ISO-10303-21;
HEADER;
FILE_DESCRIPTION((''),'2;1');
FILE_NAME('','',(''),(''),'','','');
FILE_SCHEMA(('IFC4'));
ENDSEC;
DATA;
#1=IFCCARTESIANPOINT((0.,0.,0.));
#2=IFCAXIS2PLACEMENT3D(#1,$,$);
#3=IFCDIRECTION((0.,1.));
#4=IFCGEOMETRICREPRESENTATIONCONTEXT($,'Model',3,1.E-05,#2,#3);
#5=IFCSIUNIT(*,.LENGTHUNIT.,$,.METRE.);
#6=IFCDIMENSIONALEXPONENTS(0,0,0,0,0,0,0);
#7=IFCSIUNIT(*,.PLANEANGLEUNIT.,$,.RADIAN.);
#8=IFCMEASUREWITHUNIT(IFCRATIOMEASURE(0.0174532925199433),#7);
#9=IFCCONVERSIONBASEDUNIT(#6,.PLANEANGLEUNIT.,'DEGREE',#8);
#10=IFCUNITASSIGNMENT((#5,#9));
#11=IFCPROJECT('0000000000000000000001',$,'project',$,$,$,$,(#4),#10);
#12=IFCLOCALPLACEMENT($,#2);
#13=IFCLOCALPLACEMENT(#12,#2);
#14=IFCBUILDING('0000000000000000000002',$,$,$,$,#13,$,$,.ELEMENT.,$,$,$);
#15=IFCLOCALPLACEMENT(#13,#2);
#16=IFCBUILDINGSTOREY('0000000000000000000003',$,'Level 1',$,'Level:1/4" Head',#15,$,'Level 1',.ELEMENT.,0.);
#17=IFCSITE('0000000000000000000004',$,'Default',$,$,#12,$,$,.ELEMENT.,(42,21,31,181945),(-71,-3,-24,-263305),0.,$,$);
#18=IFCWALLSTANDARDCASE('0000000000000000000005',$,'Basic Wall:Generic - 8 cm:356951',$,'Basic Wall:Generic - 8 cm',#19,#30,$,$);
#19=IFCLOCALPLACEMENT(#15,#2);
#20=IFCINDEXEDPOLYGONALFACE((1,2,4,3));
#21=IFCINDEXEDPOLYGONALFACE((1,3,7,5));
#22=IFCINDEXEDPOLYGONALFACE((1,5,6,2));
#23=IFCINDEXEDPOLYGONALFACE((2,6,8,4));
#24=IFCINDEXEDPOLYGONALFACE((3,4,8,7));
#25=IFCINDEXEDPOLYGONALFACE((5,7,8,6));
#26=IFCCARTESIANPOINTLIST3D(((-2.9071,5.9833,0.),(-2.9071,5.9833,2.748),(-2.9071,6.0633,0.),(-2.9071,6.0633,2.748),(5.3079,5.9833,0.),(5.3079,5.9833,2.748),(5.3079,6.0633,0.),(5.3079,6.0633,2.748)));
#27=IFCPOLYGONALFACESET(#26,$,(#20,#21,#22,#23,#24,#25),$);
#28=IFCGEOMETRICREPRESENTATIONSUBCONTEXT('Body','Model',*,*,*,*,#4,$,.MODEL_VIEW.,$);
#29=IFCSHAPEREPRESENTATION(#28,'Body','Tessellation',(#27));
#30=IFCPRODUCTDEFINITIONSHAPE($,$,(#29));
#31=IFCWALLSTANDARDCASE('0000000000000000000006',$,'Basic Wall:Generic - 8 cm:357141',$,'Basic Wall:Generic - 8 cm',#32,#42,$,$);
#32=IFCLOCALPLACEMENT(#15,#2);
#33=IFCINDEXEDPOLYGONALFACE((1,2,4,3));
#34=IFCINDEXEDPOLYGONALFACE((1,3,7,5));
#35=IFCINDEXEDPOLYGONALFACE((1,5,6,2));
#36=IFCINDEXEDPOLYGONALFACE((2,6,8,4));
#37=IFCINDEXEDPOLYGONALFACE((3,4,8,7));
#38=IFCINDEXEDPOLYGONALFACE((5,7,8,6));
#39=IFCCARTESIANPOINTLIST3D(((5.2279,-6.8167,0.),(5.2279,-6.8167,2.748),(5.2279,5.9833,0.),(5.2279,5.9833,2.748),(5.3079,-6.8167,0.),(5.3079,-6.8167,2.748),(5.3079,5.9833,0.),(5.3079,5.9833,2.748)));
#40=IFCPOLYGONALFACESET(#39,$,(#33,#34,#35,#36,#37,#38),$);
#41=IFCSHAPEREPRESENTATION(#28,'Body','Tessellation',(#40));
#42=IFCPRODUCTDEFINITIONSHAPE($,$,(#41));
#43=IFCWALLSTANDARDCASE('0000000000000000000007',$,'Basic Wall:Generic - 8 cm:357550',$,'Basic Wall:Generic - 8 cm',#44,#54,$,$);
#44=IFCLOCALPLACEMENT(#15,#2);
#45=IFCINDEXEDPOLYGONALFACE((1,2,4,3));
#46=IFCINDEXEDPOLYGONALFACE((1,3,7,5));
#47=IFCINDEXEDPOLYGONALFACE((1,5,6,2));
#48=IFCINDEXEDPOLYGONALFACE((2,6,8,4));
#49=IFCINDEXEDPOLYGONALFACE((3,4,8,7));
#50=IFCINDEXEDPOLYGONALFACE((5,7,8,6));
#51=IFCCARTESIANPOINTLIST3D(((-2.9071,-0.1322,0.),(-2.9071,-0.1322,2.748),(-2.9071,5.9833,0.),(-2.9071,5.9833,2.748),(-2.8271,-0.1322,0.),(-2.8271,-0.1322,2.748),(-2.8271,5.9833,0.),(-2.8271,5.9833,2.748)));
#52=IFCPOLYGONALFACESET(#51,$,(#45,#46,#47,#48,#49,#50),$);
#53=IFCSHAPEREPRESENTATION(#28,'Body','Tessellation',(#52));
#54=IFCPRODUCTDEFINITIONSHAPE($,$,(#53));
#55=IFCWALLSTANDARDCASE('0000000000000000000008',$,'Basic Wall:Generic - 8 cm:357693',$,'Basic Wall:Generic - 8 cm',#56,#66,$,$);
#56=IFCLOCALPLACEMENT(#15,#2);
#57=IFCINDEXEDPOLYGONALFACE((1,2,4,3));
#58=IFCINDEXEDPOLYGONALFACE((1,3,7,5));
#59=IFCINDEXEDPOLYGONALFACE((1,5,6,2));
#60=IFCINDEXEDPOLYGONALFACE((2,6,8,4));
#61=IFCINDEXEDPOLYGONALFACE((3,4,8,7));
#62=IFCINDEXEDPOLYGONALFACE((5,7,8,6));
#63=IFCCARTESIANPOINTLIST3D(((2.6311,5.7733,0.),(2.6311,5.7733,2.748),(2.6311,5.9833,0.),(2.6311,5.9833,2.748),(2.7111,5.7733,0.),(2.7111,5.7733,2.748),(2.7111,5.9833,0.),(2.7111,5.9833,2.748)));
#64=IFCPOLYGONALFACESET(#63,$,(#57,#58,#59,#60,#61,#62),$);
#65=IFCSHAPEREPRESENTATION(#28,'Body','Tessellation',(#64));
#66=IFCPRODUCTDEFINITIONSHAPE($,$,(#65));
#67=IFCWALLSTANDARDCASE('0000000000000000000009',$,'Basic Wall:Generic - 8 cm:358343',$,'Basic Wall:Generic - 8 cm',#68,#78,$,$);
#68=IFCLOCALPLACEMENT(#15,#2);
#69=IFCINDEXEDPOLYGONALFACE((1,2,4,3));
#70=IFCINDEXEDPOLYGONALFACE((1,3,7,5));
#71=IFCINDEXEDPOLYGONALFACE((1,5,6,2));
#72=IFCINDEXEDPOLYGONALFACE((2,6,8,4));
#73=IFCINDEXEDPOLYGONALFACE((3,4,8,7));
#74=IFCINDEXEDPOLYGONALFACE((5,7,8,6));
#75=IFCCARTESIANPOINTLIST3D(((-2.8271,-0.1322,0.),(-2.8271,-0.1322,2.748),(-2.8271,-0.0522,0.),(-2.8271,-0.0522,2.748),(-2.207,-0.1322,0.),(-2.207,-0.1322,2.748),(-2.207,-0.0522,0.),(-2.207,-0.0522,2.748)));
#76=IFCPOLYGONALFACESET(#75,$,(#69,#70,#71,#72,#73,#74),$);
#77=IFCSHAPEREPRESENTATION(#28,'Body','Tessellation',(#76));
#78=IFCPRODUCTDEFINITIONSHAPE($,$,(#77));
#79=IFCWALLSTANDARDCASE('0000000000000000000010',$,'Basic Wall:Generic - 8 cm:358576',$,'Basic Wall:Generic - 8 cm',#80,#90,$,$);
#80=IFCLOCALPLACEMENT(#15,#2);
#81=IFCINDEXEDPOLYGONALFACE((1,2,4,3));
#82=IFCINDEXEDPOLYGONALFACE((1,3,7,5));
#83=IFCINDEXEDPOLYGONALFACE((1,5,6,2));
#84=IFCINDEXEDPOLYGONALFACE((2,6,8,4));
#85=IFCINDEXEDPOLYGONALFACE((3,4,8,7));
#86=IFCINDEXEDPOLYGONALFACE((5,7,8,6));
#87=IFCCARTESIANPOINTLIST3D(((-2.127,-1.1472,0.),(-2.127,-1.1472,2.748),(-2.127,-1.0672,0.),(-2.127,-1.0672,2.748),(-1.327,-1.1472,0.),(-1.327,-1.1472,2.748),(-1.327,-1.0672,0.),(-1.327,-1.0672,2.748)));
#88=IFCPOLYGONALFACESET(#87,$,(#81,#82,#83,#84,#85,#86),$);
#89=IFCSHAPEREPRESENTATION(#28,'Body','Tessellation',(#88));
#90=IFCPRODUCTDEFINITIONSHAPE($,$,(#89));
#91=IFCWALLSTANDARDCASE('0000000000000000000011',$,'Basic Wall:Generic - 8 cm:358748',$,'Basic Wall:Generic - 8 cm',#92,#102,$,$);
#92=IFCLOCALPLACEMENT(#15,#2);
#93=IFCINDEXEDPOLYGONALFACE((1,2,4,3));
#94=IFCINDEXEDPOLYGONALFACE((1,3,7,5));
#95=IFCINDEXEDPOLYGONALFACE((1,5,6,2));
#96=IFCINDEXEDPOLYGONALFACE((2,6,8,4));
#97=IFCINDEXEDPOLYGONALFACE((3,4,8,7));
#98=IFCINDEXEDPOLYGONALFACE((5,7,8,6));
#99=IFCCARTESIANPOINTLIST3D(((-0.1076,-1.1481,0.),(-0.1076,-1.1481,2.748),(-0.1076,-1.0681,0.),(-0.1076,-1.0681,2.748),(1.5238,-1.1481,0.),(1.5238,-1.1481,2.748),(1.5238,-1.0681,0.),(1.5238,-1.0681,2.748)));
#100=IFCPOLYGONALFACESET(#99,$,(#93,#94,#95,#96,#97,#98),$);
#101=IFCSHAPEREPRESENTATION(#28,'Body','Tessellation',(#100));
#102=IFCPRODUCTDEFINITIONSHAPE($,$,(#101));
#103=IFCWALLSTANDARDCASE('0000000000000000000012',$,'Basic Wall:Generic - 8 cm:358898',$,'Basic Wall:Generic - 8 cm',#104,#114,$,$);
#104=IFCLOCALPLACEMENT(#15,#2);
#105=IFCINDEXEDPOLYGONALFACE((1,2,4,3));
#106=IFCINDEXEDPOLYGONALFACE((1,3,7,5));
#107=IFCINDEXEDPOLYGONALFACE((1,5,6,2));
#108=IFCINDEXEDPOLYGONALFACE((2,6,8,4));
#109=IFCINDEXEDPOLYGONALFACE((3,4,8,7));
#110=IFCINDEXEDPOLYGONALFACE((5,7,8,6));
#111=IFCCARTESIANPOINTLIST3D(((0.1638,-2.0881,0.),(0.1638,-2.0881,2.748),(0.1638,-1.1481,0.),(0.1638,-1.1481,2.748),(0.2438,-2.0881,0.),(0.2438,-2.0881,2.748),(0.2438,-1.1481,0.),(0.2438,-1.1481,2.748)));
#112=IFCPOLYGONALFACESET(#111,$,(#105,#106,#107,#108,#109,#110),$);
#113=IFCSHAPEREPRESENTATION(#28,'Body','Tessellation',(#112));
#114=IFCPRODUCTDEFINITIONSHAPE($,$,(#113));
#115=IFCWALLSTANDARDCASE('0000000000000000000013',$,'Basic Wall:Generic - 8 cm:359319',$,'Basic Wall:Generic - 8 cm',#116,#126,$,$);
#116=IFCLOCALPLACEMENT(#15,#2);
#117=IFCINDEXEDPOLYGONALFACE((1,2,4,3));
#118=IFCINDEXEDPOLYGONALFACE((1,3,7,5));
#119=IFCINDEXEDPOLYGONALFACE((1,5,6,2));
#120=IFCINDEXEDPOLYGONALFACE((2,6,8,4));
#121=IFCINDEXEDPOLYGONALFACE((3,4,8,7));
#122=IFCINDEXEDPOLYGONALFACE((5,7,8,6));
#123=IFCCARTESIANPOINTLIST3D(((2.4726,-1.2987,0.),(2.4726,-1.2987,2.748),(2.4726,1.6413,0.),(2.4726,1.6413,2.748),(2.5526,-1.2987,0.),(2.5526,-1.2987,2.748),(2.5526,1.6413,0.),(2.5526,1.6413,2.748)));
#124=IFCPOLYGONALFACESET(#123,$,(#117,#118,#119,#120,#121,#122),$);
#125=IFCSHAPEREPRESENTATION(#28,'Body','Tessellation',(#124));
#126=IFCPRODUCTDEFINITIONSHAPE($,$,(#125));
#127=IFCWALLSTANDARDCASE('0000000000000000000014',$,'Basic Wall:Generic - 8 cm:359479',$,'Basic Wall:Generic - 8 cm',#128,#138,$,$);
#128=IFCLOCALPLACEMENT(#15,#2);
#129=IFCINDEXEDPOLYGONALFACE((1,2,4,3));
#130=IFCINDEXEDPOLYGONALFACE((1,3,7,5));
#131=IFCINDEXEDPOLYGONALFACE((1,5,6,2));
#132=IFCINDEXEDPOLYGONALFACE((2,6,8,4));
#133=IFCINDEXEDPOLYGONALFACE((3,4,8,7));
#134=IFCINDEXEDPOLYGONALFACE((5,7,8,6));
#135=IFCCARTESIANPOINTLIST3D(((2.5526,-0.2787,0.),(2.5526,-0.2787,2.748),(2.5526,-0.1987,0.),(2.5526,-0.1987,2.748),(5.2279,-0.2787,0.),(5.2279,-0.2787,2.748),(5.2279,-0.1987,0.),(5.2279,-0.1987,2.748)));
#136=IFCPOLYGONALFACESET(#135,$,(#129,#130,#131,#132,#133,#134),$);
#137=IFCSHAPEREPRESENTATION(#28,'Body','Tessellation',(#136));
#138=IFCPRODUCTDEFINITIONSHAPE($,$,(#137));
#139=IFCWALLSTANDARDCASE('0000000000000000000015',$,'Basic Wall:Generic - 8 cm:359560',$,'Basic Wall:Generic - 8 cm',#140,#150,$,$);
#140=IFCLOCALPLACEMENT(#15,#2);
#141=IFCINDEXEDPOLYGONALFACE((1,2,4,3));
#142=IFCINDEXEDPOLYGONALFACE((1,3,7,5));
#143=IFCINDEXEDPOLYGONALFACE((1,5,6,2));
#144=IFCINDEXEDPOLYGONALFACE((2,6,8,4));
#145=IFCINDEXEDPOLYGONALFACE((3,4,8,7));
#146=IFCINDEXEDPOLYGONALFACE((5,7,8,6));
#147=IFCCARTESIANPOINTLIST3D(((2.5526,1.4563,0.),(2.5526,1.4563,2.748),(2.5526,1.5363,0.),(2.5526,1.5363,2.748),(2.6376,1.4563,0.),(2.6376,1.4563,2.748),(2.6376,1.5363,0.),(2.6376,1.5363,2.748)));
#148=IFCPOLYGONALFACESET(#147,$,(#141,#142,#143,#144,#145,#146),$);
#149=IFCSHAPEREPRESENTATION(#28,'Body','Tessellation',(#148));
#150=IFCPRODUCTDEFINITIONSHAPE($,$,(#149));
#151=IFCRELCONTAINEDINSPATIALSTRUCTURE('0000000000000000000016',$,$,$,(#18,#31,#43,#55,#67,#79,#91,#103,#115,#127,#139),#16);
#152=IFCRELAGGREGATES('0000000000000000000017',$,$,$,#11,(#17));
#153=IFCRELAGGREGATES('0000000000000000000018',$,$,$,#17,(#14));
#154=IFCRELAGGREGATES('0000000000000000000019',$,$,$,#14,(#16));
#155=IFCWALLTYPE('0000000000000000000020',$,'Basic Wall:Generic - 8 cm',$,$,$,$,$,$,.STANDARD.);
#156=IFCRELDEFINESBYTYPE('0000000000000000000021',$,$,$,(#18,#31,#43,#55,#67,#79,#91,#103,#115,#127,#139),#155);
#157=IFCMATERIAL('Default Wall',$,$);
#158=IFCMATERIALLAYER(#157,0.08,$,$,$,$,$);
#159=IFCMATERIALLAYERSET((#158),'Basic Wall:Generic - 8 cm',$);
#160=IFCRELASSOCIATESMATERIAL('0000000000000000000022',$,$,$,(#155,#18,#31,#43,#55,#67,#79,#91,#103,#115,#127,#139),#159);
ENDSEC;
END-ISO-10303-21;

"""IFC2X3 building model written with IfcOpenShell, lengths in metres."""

from ifc_helpers import new_model, entity, si_unit, converted_unit, direction, frame, frame_2d, origin, place, context, subcontext, project, spatial, rectangle, extrude, material, layer, layer_set, layer_usage, type_object, element, save


model = new_model("IFC2X3")

# Units and contexts
model_context = context("Model", 3, precision=1e-05, world=origin(), true_north=direction((0.0, 1.0)))
body_context = subcontext(model_context, "Body", "Model", "MODEL_VIEW")
ifc_project = project(units=[si_unit("LENGTHUNIT", "METRE"), converted_unit("PLANEANGLEUNIT", "DEGREE", entity("IfcRatioMeasure", 0.0174532925199433), si_unit("PLANEANGLEUNIT", "RADIAN"), dimensions=[0, 0, 0, 0, 0, 0, 0])], contexts=[model_context])

# Site, building, storey
site_placement = place(None, origin())
site = spatial("IfcSite", under=ifc_project, at=site_placement, Name="Default", CompositionType="ELEMENT", RefLatitude=(42, 21, 31, 181945), RefLongitude=(-71, -3, -24, -263305), RefElevation=0.0)
building_placement = place(site_placement, origin())
building = spatial("IfcBuilding", under=site, at=building_placement, CompositionType="ELEMENT")
storey_placement = place(building_placement, origin())
storey = spatial("IfcBuildingStorey", under=building, at=storey_placement, Name="Level 1", ObjectType="Level:1/4\" Head", LongName="Level 1", CompositionType="ELEMENT", Elevation=0.0)

# Shared definitions
ifc_material_1 = material(Name="Default Wall")
ifc_layer_1 = layer(ifc_material_1, 0.08)
ifc_layer_set_1 = layer_set([ifc_layer_1], Name="Basic Wall:Generic - 8 cm")
wall_type = type_object("IfcWallType", Name="Basic Wall:Generic - 8 cm", PredefinedType="STANDARD", material=ifc_layer_set_1)

# Walls
ifc_layer_usage_1 = layer_usage(ifc_layer_set_1, "AXIS2", "NEGATIVE", 0.04)
wall_1_placement = place(storey_placement, frame((-2.9071, 6.0233, 0.0)))
element("IfcWallStandardCase", 1, at=wall_1_placement, inside=storey, type_object=wall_type, material=ifc_layer_usage_1, Name="Basic Wall:Generic - 8 cm:356951", ObjectType="Basic Wall:Generic - 8 cm", context=body_context, shape_type="SweptSolid", body=[
    extrude(rectangle(XDim=8.215, YDim=0.08, at=frame_2d((4.1075, 0.0), x_axis=(-1.0, 0.0))), origin(), (0.0, 0.0, 1.0), 2.748),
])
ifc_layer_usage_2 = layer_usage(ifc_layer_set_1, "AXIS2", "NEGATIVE", 0.04)
wall_2_placement = place(storey_placement, frame((5.2679, 5.9833, 0.0), z_axis=(0.0, 0.0, 1.0), x_axis=(0.0, -1.0, 0.0)))
element("IfcWallStandardCase", 2, at=wall_2_placement, inside=storey, type_object=wall_type, material=ifc_layer_usage_2, Name="Basic Wall:Generic - 8 cm:357141", ObjectType="Basic Wall:Generic - 8 cm", context=body_context, shape_type="SweptSolid", body=[
    extrude(rectangle(XDim=12.8, YDim=0.08, at=frame_2d((6.4, 0.0), x_axis=(-1.0, 0.0))), origin(), (0.0, 0.0, 1.0), 2.748),
])
ifc_layer_usage_3 = layer_usage(ifc_layer_set_1, "AXIS2", "NEGATIVE", 0.04)
wall_3_placement = place(storey_placement, frame((-2.8671, 5.9833, 0.0), z_axis=(0.0, 0.0, 1.0), x_axis=(0.0, -1.0, 0.0)))
element("IfcWallStandardCase", 3, at=wall_3_placement, inside=storey, type_object=wall_type, material=ifc_layer_usage_3, Name="Basic Wall:Generic - 8 cm:357550", ObjectType="Basic Wall:Generic - 8 cm", context=body_context, shape_type="SweptSolid", body=[
    extrude(rectangle(XDim=6.1155, YDim=0.08, at=frame_2d((3.0577, 0.0), x_axis=(-1.0, 0.0))), origin(), (0.0, 0.0, 1.0), 2.748),
])
ifc_layer_usage_4 = layer_usage(ifc_layer_set_1, "AXIS2", "NEGATIVE", 0.04)
wall_4_placement = place(storey_placement, frame((2.6711, 5.9833, 0.0), z_axis=(0.0, 0.0, 1.0), x_axis=(0.0, -1.0, 0.0)))
element("IfcWallStandardCase", 4, at=wall_4_placement, inside=storey, type_object=wall_type, material=ifc_layer_usage_4, Name="Basic Wall:Generic - 8 cm:357693", ObjectType="Basic Wall:Generic - 8 cm", context=body_context, shape_type="SweptSolid", body=[
    extrude(rectangle(XDim=0.21, YDim=0.08, at=frame_2d((0.105, 0.0), x_axis=(-1.0, 0.0))), origin(), (0.0, 0.0, 1.0), 2.748),
])
ifc_layer_usage_5 = layer_usage(ifc_layer_set_1, "AXIS2", "NEGATIVE", 0.04)
wall_5_placement = place(storey_placement, frame((-2.207, -0.0922, 0.0), z_axis=(0.0, 0.0, 1.0), x_axis=(-1.0, 0.0, 0.0)))
element("IfcWallStandardCase", 5, at=wall_5_placement, inside=storey, type_object=wall_type, material=ifc_layer_usage_5, Name="Basic Wall:Generic - 8 cm:358343", ObjectType="Basic Wall:Generic - 8 cm", context=body_context, shape_type="SweptSolid", body=[
    extrude(rectangle(XDim=0.6201, YDim=0.08, at=frame_2d((0.3101, 0.0), x_axis=(-1.0, 0.0))), origin(), (0.0, 0.0, 1.0), 2.748),
])
ifc_layer_usage_6 = layer_usage(ifc_layer_set_1, "AXIS2", "NEGATIVE", 0.04)
wall_6_placement = place(storey_placement, frame((-2.127, -1.1072, 0.0)))
element("IfcWallStandardCase", 6, at=wall_6_placement, inside=storey, type_object=wall_type, material=ifc_layer_usage_6, Name="Basic Wall:Generic - 8 cm:358576", ObjectType="Basic Wall:Generic - 8 cm", context=body_context, shape_type="SweptSolid", body=[
    extrude(rectangle(XDim=0.8, YDim=0.08, at=frame_2d((0.4, 0.0), x_axis=(-1.0, 0.0))), origin(), (0.0, 0.0, 1.0), 2.748),
])
ifc_layer_usage_7 = layer_usage(ifc_layer_set_1, "AXIS2", "NEGATIVE", 0.04)
wall_7_placement = place(storey_placement, frame((-0.1076, -1.1081, 0.0)))
element("IfcWallStandardCase", 7, at=wall_7_placement, inside=storey, type_object=wall_type, material=ifc_layer_usage_7, Name="Basic Wall:Generic - 8 cm:358748", ObjectType="Basic Wall:Generic - 8 cm", context=body_context, shape_type="SweptSolid", body=[
    extrude(rectangle(XDim=1.6314, YDim=0.08, at=frame_2d((0.8157, 0.0), x_axis=(-1.0, 0.0))), origin(), (0.0, 0.0, 1.0), 2.748),
])
ifc_layer_usage_8 = layer_usage(ifc_layer_set_1, "AXIS2", "NEGATIVE", 0.04)
wall_8_placement = place(storey_placement, frame((0.2038, -1.1481, 0.0), z_axis=(0.0, 0.0, 1.0), x_axis=(0.0, -1.0, 0.0)))
element("IfcWallStandardCase", 8, at=wall_8_placement, inside=storey, type_object=wall_type, material=ifc_layer_usage_8, Name="Basic Wall:Generic - 8 cm:358898", ObjectType="Basic Wall:Generic - 8 cm", context=body_context, shape_type="SweptSolid", body=[
    extrude(rectangle(XDim=0.94, YDim=0.08, at=frame_2d((0.47, 0.0), x_axis=(-1.0, 0.0))), origin(), (0.0, 0.0, 1.0), 2.748),
])
ifc_layer_usage_9 = layer_usage(ifc_layer_set_1, "AXIS2", "NEGATIVE", 0.04)
wall_9_placement = place(storey_placement, frame((2.5126, 1.6413, 0.0), z_axis=(0.0, 0.0, 1.0), x_axis=(0.0, -1.0, 0.0)))
element("IfcWallStandardCase", 9, at=wall_9_placement, inside=storey, type_object=wall_type, material=ifc_layer_usage_9, Name="Basic Wall:Generic - 8 cm:359319", ObjectType="Basic Wall:Generic - 8 cm", context=body_context, shape_type="SweptSolid", body=[
    extrude(rectangle(XDim=2.94, YDim=0.08, at=frame_2d((1.47, 0.0), x_axis=(-1.0, 0.0))), origin(), (0.0, 0.0, 1.0), 2.748),
])
ifc_layer_usage_10 = layer_usage(ifc_layer_set_1, "AXIS2", "NEGATIVE", 0.04)
wall_10_placement = place(storey_placement, frame((5.2279, -0.2387, 0.0), z_axis=(0.0, 0.0, 1.0), x_axis=(-1.0, 0.0, 0.0)))
element("IfcWallStandardCase", 10, at=wall_10_placement, inside=storey, type_object=wall_type, material=ifc_layer_usage_10, Name="Basic Wall:Generic - 8 cm:359479", ObjectType="Basic Wall:Generic - 8 cm", context=body_context, shape_type="SweptSolid", body=[
    extrude(rectangle(XDim=2.6753, YDim=0.08, at=frame_2d((1.3377, 0.0), x_axis=(-1.0, 0.0))), origin(), (0.0, 0.0, 1.0), 2.748),
])
ifc_layer_usage_11 = layer_usage(ifc_layer_set_1, "AXIS2", "NEGATIVE", 0.04)
wall_11_placement = place(storey_placement, frame((2.5526, 1.4963, 0.0)))
element("IfcWallStandardCase", 11, at=wall_11_placement, inside=storey, type_object=wall_type, material=ifc_layer_usage_11, Name="Basic Wall:Generic - 8 cm:359560", ObjectType="Basic Wall:Generic - 8 cm", context=body_context, shape_type="SweptSolid", body=[
    extrude(rectangle(XDim=0.085, YDim=0.08, at=frame_2d((0.0425, 0.0), x_axis=(-1.0, 0.0))), origin(), (0.0, 0.0, 1.0), 2.748),
])

save(model, "model.ifc")
